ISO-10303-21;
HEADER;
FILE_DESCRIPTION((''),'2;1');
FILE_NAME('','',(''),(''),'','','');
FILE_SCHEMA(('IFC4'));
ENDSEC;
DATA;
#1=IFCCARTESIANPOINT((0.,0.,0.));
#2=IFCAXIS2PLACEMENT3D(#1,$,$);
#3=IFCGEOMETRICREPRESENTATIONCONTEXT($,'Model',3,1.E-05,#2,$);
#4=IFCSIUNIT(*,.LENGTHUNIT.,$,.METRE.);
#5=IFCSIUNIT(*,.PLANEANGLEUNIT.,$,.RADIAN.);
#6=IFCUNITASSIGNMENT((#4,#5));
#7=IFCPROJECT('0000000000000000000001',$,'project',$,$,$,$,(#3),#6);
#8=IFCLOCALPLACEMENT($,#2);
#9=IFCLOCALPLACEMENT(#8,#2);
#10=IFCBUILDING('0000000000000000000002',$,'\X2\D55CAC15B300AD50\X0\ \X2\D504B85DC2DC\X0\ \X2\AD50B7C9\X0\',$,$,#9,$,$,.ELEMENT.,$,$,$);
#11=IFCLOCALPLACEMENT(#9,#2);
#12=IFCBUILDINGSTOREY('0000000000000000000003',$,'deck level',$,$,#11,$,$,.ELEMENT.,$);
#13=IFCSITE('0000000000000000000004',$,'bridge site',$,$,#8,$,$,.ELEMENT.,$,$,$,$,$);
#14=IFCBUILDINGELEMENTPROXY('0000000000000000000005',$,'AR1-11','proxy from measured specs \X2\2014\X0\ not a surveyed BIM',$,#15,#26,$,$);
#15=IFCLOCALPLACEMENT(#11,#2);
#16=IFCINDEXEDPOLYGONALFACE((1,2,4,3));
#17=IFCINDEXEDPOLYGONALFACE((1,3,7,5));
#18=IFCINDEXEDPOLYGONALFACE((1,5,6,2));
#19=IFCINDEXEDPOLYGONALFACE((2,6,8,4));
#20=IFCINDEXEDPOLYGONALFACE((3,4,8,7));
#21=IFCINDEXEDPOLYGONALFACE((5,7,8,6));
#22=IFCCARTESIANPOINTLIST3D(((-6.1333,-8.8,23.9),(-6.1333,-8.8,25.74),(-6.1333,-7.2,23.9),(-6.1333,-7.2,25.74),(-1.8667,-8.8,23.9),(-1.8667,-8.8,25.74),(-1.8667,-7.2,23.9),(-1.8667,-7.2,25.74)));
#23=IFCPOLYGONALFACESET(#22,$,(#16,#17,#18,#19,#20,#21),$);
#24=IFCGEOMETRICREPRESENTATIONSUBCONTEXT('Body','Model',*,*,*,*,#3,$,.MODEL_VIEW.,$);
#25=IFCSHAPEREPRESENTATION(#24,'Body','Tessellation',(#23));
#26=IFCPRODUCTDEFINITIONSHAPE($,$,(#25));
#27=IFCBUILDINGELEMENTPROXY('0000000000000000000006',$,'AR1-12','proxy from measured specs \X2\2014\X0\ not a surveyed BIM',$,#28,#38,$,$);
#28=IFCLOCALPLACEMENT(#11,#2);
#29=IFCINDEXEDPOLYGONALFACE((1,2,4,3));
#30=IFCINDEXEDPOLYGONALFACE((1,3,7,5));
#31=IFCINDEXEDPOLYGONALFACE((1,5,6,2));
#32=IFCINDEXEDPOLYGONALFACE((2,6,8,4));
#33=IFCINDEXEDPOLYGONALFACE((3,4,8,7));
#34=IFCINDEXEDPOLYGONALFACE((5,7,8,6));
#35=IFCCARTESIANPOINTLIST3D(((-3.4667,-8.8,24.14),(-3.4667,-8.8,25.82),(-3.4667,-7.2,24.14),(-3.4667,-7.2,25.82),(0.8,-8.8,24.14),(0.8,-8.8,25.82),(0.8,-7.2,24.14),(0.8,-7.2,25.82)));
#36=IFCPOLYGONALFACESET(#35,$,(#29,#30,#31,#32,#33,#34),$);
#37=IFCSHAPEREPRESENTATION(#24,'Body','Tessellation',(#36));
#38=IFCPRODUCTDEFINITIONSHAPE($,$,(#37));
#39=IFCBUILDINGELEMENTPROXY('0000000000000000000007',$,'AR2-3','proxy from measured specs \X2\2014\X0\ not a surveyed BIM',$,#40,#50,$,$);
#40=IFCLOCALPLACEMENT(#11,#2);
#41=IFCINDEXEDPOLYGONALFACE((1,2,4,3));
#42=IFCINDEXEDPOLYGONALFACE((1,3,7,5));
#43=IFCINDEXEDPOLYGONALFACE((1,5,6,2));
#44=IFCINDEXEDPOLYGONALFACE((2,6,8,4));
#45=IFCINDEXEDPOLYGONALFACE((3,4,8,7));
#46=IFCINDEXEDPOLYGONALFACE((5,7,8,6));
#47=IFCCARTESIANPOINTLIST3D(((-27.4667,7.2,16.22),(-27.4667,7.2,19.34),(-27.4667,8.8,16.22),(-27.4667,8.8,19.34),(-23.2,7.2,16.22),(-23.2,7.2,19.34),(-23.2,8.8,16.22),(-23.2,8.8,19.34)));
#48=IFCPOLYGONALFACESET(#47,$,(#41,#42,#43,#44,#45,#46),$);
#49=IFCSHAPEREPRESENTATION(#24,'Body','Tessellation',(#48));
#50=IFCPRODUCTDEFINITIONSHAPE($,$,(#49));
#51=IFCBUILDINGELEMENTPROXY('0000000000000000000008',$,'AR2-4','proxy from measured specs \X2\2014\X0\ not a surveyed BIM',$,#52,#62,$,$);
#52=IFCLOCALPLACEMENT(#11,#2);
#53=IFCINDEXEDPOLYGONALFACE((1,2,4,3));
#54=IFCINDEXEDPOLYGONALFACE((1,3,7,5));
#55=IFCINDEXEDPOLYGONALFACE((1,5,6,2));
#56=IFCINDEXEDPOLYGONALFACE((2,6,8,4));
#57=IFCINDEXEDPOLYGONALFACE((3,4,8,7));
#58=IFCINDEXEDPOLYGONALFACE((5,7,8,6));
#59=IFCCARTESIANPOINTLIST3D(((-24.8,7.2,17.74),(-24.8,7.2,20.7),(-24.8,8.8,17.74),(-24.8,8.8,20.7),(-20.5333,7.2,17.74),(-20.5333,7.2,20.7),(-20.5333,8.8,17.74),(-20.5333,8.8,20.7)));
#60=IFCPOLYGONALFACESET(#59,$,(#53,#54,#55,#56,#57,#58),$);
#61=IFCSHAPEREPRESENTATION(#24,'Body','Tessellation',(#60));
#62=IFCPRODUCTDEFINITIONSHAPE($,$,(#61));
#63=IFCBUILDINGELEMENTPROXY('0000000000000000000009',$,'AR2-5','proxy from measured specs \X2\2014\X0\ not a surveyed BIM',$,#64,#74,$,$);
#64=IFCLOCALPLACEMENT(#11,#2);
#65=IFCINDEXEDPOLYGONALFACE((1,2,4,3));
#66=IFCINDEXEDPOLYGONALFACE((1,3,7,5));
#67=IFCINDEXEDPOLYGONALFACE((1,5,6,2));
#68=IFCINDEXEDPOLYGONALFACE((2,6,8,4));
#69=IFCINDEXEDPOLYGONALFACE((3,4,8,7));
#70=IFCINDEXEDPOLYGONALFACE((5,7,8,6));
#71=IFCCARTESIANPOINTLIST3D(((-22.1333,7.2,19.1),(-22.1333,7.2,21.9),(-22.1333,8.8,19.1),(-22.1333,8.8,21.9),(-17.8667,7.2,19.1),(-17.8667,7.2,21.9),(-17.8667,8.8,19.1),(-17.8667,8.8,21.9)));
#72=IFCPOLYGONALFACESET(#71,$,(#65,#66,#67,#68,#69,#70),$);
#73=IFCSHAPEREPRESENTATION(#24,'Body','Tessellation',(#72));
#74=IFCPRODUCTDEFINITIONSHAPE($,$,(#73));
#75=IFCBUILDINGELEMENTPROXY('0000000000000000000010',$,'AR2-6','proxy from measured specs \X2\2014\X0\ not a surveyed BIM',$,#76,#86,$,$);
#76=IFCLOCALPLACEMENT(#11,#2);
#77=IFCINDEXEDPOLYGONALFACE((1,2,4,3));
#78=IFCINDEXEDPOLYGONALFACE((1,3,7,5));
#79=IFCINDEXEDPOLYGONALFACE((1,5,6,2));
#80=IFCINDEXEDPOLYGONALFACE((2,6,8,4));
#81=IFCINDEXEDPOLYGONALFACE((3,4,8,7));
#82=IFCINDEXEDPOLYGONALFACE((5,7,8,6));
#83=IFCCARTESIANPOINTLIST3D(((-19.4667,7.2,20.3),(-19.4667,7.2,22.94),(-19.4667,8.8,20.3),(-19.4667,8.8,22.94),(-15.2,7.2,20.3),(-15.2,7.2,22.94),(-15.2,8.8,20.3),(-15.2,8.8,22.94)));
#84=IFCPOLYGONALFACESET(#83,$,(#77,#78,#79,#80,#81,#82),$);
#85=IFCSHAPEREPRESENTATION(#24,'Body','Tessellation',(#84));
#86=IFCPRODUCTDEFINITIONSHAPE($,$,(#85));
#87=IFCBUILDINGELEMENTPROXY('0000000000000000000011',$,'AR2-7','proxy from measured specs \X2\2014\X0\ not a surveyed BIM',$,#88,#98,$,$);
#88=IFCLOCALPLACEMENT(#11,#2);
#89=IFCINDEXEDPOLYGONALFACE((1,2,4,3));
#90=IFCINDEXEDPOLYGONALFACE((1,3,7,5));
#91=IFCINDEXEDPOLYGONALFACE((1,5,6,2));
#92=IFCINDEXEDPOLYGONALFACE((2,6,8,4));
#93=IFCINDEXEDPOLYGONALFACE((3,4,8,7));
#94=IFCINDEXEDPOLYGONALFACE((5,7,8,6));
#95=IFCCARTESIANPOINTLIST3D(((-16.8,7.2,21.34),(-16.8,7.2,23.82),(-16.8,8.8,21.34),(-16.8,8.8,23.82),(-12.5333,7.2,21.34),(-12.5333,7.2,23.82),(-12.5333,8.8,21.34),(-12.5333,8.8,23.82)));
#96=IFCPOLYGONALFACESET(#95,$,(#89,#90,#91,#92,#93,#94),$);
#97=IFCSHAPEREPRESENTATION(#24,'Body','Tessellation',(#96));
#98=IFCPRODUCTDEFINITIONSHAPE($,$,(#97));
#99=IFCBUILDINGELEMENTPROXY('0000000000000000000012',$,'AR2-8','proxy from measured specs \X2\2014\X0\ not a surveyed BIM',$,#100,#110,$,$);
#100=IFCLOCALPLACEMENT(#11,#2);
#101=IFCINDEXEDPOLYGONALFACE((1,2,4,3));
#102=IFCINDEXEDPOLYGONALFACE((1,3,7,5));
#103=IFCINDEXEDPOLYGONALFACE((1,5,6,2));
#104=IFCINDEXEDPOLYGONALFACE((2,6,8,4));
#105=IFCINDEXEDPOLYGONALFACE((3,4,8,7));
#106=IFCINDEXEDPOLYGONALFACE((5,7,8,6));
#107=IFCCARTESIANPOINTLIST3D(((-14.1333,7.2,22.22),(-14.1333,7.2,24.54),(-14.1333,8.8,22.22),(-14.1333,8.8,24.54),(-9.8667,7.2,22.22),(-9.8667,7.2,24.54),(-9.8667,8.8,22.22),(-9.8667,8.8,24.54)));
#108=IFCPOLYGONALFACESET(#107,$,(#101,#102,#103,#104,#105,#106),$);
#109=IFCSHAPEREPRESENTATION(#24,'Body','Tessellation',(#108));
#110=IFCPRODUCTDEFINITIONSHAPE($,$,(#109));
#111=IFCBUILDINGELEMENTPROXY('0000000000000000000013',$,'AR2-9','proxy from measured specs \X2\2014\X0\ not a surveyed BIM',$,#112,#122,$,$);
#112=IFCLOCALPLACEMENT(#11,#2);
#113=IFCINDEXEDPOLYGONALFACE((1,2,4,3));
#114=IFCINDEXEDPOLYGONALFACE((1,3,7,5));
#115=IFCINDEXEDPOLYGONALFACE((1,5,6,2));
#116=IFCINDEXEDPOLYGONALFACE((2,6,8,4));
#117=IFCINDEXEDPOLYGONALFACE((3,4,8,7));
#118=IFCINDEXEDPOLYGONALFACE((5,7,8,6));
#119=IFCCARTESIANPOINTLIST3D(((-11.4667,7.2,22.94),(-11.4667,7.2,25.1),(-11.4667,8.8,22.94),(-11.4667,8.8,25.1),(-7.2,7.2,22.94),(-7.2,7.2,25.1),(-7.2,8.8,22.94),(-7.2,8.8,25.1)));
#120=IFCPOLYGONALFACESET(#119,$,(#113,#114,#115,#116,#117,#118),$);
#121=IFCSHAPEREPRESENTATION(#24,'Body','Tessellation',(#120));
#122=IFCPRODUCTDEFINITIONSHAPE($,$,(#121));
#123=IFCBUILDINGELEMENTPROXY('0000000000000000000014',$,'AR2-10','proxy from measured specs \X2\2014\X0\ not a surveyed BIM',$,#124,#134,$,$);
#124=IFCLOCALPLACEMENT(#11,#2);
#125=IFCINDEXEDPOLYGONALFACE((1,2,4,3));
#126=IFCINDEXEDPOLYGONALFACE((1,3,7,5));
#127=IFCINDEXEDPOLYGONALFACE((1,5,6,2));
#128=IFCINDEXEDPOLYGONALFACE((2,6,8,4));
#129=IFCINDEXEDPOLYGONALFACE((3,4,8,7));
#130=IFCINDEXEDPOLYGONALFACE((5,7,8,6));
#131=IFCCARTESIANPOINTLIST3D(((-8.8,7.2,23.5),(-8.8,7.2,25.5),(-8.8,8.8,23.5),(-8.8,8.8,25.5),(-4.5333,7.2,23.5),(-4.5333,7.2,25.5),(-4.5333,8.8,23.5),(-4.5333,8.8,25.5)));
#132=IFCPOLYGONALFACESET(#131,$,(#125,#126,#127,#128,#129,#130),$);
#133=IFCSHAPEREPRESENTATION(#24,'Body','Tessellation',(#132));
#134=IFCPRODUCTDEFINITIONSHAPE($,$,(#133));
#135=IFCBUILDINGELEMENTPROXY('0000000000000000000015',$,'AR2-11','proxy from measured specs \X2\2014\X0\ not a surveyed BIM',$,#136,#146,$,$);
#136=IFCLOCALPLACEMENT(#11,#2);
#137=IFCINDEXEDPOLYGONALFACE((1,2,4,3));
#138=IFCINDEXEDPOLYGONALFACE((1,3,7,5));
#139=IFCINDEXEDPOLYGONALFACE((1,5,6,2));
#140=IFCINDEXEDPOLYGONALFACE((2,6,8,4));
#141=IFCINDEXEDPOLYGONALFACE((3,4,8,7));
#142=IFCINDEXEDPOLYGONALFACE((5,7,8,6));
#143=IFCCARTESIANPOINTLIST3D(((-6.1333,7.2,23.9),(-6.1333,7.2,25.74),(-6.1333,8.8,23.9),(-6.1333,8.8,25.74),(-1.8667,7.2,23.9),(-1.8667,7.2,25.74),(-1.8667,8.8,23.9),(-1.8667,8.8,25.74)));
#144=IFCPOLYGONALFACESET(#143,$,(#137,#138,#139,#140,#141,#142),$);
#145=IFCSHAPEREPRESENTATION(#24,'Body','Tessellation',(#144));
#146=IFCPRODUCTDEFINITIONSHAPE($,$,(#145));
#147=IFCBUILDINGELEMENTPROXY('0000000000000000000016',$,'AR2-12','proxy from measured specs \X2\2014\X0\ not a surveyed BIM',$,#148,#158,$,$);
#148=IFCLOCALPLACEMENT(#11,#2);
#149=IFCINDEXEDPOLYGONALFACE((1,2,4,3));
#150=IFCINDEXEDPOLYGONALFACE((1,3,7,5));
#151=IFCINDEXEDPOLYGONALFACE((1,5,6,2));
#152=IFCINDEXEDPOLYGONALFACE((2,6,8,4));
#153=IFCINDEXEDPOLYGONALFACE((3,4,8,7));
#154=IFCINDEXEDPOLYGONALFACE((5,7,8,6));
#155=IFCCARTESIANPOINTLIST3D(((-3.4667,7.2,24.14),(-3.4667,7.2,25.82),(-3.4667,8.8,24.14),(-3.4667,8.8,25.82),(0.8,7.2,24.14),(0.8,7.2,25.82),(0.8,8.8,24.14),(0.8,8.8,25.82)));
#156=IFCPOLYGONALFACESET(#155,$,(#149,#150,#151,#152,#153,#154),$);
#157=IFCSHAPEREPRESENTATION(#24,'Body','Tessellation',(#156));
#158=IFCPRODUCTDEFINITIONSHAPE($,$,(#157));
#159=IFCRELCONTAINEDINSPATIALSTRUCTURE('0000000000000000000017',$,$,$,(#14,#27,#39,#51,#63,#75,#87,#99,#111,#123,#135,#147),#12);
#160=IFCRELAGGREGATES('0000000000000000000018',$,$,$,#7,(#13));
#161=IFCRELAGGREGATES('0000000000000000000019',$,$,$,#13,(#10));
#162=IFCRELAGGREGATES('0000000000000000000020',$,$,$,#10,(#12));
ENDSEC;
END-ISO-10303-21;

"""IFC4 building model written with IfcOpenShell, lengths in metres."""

from ifc_helpers import new_model, si_unit, frame, origin, origin_2d, place, context, subcontext, project, spatial, rectangle, extrude, element, save


model = new_model("IFC4")

# Units and contexts
model_context = context("Model", 3, precision=1e-05, world=origin())
body_context = subcontext(model_context, "Body", "Model", "MODEL_VIEW")
ifc_project = project(units=[si_unit("LENGTHUNIT", "METRE"), si_unit("PLANEANGLEUNIT", "RADIAN")], contexts=[model_context])

# Site, building, storey
site_placement = place(None, origin())
site = spatial("IfcSite", under=ifc_project, at=site_placement, Name="bridge site", CompositionType="ELEMENT")
building_placement = place(site_placement, origin())
building = spatial("IfcBuilding", under=site, at=building_placement, Name="한강대교 프록시 교량", CompositionType="ELEMENT")
storey_placement = place(building_placement, origin())
storey = spatial("IfcBuildingStorey", under=building, at=storey_placement, Name="deck level", CompositionType="ELEMENT")

# Building element proxies
proxy_1_placement = place(storey_placement, frame((-4.0, -8.0, 23.9)))
element("IfcBuildingElementProxy", 1, at=proxy_1_placement, inside=storey, Name="AR1-11", Description="proxy from measured specs — not a surveyed BIM", context=body_context, shape_type="SweptSolid", body=[
    extrude(rectangle(XDim=4.2667, YDim=1.6, at=origin_2d()), origin(), (0.0, 0.0, 1.0), 1.84),
])
proxy_2_placement = place(storey_placement, frame((-1.3333, -8.0, 24.14)))
element("IfcBuildingElementProxy", 2, at=proxy_2_placement, inside=storey, Name="AR1-12", Description="proxy from measured specs — not a surveyed BIM", context=body_context, shape_type="SweptSolid", body=[
    extrude(rectangle(XDim=4.2667, YDim=1.6, at=origin_2d()), origin(), (0.0, 0.0, 1.0), 1.68),
])
proxy_3_placement = place(storey_placement, frame((-25.3333, 8.0, 16.22)))
element("IfcBuildingElementProxy", 3, at=proxy_3_placement, inside=storey, Name="AR2-3", Description="proxy from measured specs — not a surveyed BIM", context=body_context, shape_type="SweptSolid", body=[
    extrude(rectangle(XDim=4.2667, YDim=1.6, at=origin_2d()), origin(), (0.0, 0.0, 1.0), 3.12),
])
proxy_4_placement = place(storey_placement, frame((-22.6667, 8.0, 17.74)))
element("IfcBuildingElementProxy", 4, at=proxy_4_placement, inside=storey, Name="AR2-4", Description="proxy from measured specs — not a surveyed BIM", context=body_context, shape_type="SweptSolid", body=[
    extrude(rectangle(XDim=4.2667, YDim=1.6, at=origin_2d()), origin(), (0.0, 0.0, 1.0), 2.96),
])
proxy_5_placement = place(storey_placement, frame((-20.0, 8.0, 19.1)))
element("IfcBuildingElementProxy", 5, at=proxy_5_placement, inside=storey, Name="AR2-5", Description="proxy from measured specs — not a surveyed BIM", context=body_context, shape_type="SweptSolid", body=[
    extrude(rectangle(XDim=4.2667, YDim=1.6, at=origin_2d()), origin(), (0.0, 0.0, 1.0), 2.8),
])
proxy_6_placement = place(storey_placement, frame((-17.3333, 8.0, 20.3)))
element("IfcBuildingElementProxy", 6, at=proxy_6_placement, inside=storey, Name="AR2-6", Description="proxy from measured specs — not a surveyed BIM", context=body_context, shape_type="SweptSolid", body=[
    extrude(rectangle(XDim=4.2667, YDim=1.6, at=origin_2d()), origin(), (0.0, 0.0, 1.0), 2.64),
])
proxy_7_placement = place(storey_placement, frame((-14.6667, 8.0, 21.34)))
element("IfcBuildingElementProxy", 7, at=proxy_7_placement, inside=storey, Name="AR2-7", Description="proxy from measured specs — not a surveyed BIM", context=body_context, shape_type="SweptSolid", body=[
    extrude(rectangle(XDim=4.2667, YDim=1.6, at=origin_2d()), origin(), (0.0, 0.0, 1.0), 2.48),
])
proxy_8_placement = place(storey_placement, frame((-12.0, 8.0, 22.22)))
element("IfcBuildingElementProxy", 8, at=proxy_8_placement, inside=storey, Name="AR2-8", Description="proxy from measured specs — not a surveyed BIM", context=body_context, shape_type="SweptSolid", body=[
    extrude(rectangle(XDim=4.2667, YDim=1.6, at=origin_2d()), origin(), (0.0, 0.0, 1.0), 2.32),
])
proxy_9_placement = place(storey_placement, frame((-9.3333, 8.0, 22.94)))
element("IfcBuildingElementProxy", 9, at=proxy_9_placement, inside=storey, Name="AR2-9", Description="proxy from measured specs — not a surveyed BIM", context=body_context, shape_type="SweptSolid", body=[
    extrude(rectangle(XDim=4.2667, YDim=1.6, at=origin_2d()), origin(), (0.0, 0.0, 1.0), 2.16),
])
proxy_10_placement = place(storey_placement, frame((-6.6667, 8.0, 23.5)))
element("IfcBuildingElementProxy", 10, at=proxy_10_placement, inside=storey, Name="AR2-10", Description="proxy from measured specs — not a surveyed BIM", context=body_context, shape_type="SweptSolid", body=[
    extrude(rectangle(XDim=4.2667, YDim=1.6, at=origin_2d()), origin(), (0.0, 0.0, 1.0), 2.0),
])
proxy_11_placement = place(storey_placement, frame((-4.0, 8.0, 23.9)))
element("IfcBuildingElementProxy", 11, at=proxy_11_placement, inside=storey, Name="AR2-11", Description="proxy from measured specs — not a surveyed BIM", context=body_context, shape_type="SweptSolid", body=[
    extrude(rectangle(XDim=4.2667, YDim=1.6, at=origin_2d()), origin(), (0.0, 0.0, 1.0), 1.84),
])
proxy_12_placement = place(storey_placement, frame((-1.3333, 8.0, 24.14)))
element("IfcBuildingElementProxy", 12, at=proxy_12_placement, inside=storey, Name="AR2-12", Description="proxy from measured specs — not a surveyed BIM", context=body_context, shape_type="SweptSolid", body=[
    extrude(rectangle(XDim=4.2667, YDim=1.6, at=origin_2d()), origin(), (0.0, 0.0, 1.0), 1.68),
])

save(model, "model.ifc")
